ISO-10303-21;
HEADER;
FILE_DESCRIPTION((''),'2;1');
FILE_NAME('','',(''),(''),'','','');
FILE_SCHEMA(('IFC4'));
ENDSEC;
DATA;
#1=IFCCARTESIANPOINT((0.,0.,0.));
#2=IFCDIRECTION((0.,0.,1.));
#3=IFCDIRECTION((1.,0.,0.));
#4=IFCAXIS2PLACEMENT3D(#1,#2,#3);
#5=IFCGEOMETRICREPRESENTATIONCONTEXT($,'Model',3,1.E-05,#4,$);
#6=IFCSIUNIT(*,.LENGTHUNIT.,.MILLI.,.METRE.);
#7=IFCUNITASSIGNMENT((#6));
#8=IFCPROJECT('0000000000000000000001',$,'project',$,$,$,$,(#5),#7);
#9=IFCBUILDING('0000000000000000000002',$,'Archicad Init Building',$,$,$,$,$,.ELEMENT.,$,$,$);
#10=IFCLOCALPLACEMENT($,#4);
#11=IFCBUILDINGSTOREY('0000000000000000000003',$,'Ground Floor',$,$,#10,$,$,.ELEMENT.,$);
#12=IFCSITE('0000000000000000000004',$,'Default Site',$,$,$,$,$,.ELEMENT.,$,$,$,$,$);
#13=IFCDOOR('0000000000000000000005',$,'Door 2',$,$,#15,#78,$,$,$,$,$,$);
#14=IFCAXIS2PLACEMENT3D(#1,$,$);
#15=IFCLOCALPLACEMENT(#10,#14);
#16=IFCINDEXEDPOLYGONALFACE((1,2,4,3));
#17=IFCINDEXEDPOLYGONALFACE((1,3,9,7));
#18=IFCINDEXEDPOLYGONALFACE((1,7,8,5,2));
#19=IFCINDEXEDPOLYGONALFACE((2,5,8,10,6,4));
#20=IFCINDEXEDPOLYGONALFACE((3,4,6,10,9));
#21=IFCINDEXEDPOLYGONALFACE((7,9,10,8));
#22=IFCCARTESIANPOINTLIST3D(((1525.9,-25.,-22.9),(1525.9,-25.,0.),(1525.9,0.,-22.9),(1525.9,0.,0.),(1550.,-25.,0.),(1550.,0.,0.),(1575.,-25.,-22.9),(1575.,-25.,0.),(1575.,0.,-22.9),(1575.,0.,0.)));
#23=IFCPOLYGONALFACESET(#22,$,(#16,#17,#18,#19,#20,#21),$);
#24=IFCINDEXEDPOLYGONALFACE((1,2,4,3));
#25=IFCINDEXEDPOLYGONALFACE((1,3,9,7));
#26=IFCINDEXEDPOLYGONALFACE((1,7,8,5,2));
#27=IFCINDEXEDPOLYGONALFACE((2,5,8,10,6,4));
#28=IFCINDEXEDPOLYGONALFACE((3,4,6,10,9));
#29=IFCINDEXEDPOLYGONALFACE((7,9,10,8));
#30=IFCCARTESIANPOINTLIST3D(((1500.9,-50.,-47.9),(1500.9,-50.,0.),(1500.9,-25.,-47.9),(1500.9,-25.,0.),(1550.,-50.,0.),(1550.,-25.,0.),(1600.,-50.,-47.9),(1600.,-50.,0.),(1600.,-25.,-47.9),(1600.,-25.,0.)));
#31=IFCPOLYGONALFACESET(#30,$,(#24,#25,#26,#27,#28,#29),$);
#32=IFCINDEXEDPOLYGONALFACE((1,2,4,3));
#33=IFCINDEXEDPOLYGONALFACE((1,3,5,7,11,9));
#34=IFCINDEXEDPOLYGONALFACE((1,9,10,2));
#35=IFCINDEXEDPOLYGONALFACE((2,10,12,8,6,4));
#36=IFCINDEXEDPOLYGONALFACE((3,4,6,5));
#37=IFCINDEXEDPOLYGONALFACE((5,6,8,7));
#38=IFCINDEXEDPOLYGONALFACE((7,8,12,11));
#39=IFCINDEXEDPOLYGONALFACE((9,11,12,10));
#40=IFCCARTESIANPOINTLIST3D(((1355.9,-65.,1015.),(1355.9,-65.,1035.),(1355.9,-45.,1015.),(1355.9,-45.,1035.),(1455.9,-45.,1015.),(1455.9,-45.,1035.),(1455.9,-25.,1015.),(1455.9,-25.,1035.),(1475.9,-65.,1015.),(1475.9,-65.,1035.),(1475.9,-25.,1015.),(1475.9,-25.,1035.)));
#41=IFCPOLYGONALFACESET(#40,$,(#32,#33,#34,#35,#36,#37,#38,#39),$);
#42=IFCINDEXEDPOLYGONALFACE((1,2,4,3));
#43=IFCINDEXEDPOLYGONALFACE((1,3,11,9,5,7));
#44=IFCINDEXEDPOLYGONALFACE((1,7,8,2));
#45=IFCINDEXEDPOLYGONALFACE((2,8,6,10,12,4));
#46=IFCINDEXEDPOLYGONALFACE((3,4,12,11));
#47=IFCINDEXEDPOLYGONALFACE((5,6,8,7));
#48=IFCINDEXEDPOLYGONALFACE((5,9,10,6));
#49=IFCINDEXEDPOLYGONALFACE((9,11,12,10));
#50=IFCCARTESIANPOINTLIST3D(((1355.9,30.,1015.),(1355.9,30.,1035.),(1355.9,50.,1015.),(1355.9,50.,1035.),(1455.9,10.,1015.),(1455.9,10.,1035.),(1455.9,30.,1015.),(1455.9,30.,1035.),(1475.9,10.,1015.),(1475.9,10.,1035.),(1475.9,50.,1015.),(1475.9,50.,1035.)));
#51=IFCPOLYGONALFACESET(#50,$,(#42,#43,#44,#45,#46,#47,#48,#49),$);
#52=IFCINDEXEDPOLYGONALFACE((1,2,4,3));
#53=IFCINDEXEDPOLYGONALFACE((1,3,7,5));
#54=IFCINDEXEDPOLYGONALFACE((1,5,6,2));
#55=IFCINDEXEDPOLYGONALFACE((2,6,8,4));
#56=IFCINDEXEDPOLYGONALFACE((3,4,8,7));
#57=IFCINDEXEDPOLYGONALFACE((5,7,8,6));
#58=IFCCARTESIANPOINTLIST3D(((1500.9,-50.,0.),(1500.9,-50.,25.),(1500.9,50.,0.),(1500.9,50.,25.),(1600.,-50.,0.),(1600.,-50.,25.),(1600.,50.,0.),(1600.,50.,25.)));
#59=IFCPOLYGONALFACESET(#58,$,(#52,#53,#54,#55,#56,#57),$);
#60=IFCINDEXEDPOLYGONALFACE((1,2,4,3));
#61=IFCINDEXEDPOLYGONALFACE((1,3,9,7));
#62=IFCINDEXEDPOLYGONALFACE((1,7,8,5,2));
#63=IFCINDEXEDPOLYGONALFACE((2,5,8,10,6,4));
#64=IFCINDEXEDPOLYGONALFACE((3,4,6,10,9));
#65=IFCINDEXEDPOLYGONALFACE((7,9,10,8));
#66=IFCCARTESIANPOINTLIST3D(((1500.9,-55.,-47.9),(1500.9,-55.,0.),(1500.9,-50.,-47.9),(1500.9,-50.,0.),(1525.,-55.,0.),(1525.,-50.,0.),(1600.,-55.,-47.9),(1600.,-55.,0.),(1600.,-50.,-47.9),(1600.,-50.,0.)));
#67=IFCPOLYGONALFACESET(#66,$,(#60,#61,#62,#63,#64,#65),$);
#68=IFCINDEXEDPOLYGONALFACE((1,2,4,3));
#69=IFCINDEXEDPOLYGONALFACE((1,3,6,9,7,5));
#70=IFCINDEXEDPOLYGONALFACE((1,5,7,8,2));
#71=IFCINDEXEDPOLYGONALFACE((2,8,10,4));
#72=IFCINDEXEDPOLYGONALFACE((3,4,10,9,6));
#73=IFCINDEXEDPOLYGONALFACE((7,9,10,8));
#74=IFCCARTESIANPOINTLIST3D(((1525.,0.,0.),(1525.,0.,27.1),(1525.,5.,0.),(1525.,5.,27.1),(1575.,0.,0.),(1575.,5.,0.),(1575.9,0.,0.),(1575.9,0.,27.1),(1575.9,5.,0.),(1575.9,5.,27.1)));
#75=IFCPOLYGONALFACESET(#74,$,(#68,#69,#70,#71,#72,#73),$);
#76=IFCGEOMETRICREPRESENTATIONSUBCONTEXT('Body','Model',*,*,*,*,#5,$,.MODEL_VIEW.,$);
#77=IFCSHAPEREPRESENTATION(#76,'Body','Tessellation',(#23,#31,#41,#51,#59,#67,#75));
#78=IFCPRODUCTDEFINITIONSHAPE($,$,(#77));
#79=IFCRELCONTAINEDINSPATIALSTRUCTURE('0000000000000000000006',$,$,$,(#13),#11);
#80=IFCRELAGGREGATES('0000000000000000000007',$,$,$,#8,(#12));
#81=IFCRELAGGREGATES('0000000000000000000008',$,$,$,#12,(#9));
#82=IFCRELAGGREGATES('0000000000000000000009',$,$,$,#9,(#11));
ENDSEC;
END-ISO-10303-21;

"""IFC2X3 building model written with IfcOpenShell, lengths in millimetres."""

from ifc_helpers import new_model, si_unit, frame, origin_with_axes, place, context, subcontext, project, spatial, polyline, outline, extrude, element, save


model = new_model("IFC2X3")

# Units and contexts
model_context = context("Model", 3, precision=1e-05, world=origin_with_axes())
body_context = subcontext(model_context, "Body", "Model", "MODEL_VIEW")
ifc_project = project(units=[si_unit("LENGTHUNIT", "METRE", prefix="MILLI")], contexts=[model_context])

# Site, building, storey
site = spatial("IfcSite", under=ifc_project, Name="Default Site", CompositionType="ELEMENT")
building = spatial("IfcBuilding", under=site, Name="Archicad Init Building", CompositionType="ELEMENT")
storey_placement = place(None, origin_with_axes())
storey = spatial("IfcBuildingStorey", under=building, at=storey_placement, Name="Ground Floor", CompositionType="ELEMENT")

# Door
door_1_placement = place(storey_placement, frame((1550.0, -50.0, 0.0), z_axis=(0.0, 0.0, 1.0), x_axis=(1.0, 0.0, 0.0)))
element("IfcDoor", 1, at=door_1_placement, inside=storey, Name="Door 2", context=body_context, shape_type="SweptSolid", body=[
    extrude(outline(polyline([(0.0, 0.0), (0.0, 2.1), (0.9, 2.1), (0.9, 0.0), (-24.1, 0.0), (-24.1, -22.9), (25.0, -22.9), (25.0, 0.0), (0.0, 0.0)])), frame((0.0, 25.0, 0.0), z_axis=(0.0, -1.0, 0.0), x_axis=(1.0, 0.0, 0.0)), (0.0, 0.0, -1.0), 25.0),
    extrude(outline(polyline([(0.0, 0.0), (0.0, 2.1), (0.9, 2.1), (0.9, 0.0), (-49.1, 0.0), (-49.1, -47.9), (50.0, -47.9), (50.0, 0.0), (0.0, 0.0)])), frame((0.0, 0.0, 0.0), z_axis=(0.0, -1.0, 0.0), x_axis=(1.0, 0.0, 0.0)), (0.0, 0.0, -1.0), 25.0),
    extrude(outline(polyline([(0.0, 0.0), (-49.1, 0.0), (-49.1, 35.0), (0.0, 35.0), (0.0, 0.0)])), frame((25.0, 25.0, 25.0), z_axis=(0.0, 0.0, 1.0), x_axis=(1.0, 0.0, 0.0)), (0.0, 0.0, 1.0), -47.9),
    extrude(outline(polyline([(0.0, 0.0), (0.0, -40.0), (-120.0, -40.0), (-120.0, -20.0), (-20.0, -20.0), (-20.0, 0.0), (0.0, 0.0)])), frame((-74.1, 25.0, 1015.0), z_axis=(0.0, 0.0, 1.0), x_axis=(1.0, 0.0, 0.0)), (0.0, 0.0, 1.0), 20.0),
    extrude(outline(polyline([(0.0, 0.0), (0.0, 40.0), (-120.0, 40.0), (-120.0, 20.0), (-20.0, 20.0), (-20.0, 0.0), (0.0, 0.0)])), frame((-74.1, 60.0, 1015.0), z_axis=(0.0, 0.0, 1.0), x_axis=(1.0, 0.0, 0.0)), (0.0, 0.0, 1.0), 20.0),
    extrude(outline(polyline([(0.0, 0.0), (-99.1, 0.0), (-99.1, 100.0), (0.0, 100.0), (0.0, 0.0)])), frame((50.0, 0.0, 0.0), z_axis=(0.0, 0.0, 1.0), x_axis=(1.0, 0.0, 0.0)), (0.0, 0.0, 1.0), 25.0),
    extrude(outline(polyline([(0.0, 0.0), (0.0, 27.1), (50.9, 27.1), (50.9, 0.0), (-24.1, 0.0), (-24.1, -47.9), (75.0, -47.9), (75.0, 0.0), (0.0, 0.0)])), frame((-25.0, -5.0, 0.0), z_axis=(0.0, -1.0, 0.0), x_axis=(1.0, 0.0, 0.0)), (0.0, 0.0, -1.0), 5.0),
    extrude(outline(polyline([(0.0, 0.0), (0.0, 27.1), (50.9, 27.1), (50.9, 0.0), (0.9, 0.0), (0.9, -22.9), (50.0, -22.9), (50.0, 0.0), (0.0, 0.0)])), frame((-25.0, 50.0, 0.0), z_axis=(0.0, -1.0, 0.0), x_axis=(1.0, 0.0, 0.0)), (0.0, 0.0, -1.0), 5.0),
])

save(model, "model.ifc")
